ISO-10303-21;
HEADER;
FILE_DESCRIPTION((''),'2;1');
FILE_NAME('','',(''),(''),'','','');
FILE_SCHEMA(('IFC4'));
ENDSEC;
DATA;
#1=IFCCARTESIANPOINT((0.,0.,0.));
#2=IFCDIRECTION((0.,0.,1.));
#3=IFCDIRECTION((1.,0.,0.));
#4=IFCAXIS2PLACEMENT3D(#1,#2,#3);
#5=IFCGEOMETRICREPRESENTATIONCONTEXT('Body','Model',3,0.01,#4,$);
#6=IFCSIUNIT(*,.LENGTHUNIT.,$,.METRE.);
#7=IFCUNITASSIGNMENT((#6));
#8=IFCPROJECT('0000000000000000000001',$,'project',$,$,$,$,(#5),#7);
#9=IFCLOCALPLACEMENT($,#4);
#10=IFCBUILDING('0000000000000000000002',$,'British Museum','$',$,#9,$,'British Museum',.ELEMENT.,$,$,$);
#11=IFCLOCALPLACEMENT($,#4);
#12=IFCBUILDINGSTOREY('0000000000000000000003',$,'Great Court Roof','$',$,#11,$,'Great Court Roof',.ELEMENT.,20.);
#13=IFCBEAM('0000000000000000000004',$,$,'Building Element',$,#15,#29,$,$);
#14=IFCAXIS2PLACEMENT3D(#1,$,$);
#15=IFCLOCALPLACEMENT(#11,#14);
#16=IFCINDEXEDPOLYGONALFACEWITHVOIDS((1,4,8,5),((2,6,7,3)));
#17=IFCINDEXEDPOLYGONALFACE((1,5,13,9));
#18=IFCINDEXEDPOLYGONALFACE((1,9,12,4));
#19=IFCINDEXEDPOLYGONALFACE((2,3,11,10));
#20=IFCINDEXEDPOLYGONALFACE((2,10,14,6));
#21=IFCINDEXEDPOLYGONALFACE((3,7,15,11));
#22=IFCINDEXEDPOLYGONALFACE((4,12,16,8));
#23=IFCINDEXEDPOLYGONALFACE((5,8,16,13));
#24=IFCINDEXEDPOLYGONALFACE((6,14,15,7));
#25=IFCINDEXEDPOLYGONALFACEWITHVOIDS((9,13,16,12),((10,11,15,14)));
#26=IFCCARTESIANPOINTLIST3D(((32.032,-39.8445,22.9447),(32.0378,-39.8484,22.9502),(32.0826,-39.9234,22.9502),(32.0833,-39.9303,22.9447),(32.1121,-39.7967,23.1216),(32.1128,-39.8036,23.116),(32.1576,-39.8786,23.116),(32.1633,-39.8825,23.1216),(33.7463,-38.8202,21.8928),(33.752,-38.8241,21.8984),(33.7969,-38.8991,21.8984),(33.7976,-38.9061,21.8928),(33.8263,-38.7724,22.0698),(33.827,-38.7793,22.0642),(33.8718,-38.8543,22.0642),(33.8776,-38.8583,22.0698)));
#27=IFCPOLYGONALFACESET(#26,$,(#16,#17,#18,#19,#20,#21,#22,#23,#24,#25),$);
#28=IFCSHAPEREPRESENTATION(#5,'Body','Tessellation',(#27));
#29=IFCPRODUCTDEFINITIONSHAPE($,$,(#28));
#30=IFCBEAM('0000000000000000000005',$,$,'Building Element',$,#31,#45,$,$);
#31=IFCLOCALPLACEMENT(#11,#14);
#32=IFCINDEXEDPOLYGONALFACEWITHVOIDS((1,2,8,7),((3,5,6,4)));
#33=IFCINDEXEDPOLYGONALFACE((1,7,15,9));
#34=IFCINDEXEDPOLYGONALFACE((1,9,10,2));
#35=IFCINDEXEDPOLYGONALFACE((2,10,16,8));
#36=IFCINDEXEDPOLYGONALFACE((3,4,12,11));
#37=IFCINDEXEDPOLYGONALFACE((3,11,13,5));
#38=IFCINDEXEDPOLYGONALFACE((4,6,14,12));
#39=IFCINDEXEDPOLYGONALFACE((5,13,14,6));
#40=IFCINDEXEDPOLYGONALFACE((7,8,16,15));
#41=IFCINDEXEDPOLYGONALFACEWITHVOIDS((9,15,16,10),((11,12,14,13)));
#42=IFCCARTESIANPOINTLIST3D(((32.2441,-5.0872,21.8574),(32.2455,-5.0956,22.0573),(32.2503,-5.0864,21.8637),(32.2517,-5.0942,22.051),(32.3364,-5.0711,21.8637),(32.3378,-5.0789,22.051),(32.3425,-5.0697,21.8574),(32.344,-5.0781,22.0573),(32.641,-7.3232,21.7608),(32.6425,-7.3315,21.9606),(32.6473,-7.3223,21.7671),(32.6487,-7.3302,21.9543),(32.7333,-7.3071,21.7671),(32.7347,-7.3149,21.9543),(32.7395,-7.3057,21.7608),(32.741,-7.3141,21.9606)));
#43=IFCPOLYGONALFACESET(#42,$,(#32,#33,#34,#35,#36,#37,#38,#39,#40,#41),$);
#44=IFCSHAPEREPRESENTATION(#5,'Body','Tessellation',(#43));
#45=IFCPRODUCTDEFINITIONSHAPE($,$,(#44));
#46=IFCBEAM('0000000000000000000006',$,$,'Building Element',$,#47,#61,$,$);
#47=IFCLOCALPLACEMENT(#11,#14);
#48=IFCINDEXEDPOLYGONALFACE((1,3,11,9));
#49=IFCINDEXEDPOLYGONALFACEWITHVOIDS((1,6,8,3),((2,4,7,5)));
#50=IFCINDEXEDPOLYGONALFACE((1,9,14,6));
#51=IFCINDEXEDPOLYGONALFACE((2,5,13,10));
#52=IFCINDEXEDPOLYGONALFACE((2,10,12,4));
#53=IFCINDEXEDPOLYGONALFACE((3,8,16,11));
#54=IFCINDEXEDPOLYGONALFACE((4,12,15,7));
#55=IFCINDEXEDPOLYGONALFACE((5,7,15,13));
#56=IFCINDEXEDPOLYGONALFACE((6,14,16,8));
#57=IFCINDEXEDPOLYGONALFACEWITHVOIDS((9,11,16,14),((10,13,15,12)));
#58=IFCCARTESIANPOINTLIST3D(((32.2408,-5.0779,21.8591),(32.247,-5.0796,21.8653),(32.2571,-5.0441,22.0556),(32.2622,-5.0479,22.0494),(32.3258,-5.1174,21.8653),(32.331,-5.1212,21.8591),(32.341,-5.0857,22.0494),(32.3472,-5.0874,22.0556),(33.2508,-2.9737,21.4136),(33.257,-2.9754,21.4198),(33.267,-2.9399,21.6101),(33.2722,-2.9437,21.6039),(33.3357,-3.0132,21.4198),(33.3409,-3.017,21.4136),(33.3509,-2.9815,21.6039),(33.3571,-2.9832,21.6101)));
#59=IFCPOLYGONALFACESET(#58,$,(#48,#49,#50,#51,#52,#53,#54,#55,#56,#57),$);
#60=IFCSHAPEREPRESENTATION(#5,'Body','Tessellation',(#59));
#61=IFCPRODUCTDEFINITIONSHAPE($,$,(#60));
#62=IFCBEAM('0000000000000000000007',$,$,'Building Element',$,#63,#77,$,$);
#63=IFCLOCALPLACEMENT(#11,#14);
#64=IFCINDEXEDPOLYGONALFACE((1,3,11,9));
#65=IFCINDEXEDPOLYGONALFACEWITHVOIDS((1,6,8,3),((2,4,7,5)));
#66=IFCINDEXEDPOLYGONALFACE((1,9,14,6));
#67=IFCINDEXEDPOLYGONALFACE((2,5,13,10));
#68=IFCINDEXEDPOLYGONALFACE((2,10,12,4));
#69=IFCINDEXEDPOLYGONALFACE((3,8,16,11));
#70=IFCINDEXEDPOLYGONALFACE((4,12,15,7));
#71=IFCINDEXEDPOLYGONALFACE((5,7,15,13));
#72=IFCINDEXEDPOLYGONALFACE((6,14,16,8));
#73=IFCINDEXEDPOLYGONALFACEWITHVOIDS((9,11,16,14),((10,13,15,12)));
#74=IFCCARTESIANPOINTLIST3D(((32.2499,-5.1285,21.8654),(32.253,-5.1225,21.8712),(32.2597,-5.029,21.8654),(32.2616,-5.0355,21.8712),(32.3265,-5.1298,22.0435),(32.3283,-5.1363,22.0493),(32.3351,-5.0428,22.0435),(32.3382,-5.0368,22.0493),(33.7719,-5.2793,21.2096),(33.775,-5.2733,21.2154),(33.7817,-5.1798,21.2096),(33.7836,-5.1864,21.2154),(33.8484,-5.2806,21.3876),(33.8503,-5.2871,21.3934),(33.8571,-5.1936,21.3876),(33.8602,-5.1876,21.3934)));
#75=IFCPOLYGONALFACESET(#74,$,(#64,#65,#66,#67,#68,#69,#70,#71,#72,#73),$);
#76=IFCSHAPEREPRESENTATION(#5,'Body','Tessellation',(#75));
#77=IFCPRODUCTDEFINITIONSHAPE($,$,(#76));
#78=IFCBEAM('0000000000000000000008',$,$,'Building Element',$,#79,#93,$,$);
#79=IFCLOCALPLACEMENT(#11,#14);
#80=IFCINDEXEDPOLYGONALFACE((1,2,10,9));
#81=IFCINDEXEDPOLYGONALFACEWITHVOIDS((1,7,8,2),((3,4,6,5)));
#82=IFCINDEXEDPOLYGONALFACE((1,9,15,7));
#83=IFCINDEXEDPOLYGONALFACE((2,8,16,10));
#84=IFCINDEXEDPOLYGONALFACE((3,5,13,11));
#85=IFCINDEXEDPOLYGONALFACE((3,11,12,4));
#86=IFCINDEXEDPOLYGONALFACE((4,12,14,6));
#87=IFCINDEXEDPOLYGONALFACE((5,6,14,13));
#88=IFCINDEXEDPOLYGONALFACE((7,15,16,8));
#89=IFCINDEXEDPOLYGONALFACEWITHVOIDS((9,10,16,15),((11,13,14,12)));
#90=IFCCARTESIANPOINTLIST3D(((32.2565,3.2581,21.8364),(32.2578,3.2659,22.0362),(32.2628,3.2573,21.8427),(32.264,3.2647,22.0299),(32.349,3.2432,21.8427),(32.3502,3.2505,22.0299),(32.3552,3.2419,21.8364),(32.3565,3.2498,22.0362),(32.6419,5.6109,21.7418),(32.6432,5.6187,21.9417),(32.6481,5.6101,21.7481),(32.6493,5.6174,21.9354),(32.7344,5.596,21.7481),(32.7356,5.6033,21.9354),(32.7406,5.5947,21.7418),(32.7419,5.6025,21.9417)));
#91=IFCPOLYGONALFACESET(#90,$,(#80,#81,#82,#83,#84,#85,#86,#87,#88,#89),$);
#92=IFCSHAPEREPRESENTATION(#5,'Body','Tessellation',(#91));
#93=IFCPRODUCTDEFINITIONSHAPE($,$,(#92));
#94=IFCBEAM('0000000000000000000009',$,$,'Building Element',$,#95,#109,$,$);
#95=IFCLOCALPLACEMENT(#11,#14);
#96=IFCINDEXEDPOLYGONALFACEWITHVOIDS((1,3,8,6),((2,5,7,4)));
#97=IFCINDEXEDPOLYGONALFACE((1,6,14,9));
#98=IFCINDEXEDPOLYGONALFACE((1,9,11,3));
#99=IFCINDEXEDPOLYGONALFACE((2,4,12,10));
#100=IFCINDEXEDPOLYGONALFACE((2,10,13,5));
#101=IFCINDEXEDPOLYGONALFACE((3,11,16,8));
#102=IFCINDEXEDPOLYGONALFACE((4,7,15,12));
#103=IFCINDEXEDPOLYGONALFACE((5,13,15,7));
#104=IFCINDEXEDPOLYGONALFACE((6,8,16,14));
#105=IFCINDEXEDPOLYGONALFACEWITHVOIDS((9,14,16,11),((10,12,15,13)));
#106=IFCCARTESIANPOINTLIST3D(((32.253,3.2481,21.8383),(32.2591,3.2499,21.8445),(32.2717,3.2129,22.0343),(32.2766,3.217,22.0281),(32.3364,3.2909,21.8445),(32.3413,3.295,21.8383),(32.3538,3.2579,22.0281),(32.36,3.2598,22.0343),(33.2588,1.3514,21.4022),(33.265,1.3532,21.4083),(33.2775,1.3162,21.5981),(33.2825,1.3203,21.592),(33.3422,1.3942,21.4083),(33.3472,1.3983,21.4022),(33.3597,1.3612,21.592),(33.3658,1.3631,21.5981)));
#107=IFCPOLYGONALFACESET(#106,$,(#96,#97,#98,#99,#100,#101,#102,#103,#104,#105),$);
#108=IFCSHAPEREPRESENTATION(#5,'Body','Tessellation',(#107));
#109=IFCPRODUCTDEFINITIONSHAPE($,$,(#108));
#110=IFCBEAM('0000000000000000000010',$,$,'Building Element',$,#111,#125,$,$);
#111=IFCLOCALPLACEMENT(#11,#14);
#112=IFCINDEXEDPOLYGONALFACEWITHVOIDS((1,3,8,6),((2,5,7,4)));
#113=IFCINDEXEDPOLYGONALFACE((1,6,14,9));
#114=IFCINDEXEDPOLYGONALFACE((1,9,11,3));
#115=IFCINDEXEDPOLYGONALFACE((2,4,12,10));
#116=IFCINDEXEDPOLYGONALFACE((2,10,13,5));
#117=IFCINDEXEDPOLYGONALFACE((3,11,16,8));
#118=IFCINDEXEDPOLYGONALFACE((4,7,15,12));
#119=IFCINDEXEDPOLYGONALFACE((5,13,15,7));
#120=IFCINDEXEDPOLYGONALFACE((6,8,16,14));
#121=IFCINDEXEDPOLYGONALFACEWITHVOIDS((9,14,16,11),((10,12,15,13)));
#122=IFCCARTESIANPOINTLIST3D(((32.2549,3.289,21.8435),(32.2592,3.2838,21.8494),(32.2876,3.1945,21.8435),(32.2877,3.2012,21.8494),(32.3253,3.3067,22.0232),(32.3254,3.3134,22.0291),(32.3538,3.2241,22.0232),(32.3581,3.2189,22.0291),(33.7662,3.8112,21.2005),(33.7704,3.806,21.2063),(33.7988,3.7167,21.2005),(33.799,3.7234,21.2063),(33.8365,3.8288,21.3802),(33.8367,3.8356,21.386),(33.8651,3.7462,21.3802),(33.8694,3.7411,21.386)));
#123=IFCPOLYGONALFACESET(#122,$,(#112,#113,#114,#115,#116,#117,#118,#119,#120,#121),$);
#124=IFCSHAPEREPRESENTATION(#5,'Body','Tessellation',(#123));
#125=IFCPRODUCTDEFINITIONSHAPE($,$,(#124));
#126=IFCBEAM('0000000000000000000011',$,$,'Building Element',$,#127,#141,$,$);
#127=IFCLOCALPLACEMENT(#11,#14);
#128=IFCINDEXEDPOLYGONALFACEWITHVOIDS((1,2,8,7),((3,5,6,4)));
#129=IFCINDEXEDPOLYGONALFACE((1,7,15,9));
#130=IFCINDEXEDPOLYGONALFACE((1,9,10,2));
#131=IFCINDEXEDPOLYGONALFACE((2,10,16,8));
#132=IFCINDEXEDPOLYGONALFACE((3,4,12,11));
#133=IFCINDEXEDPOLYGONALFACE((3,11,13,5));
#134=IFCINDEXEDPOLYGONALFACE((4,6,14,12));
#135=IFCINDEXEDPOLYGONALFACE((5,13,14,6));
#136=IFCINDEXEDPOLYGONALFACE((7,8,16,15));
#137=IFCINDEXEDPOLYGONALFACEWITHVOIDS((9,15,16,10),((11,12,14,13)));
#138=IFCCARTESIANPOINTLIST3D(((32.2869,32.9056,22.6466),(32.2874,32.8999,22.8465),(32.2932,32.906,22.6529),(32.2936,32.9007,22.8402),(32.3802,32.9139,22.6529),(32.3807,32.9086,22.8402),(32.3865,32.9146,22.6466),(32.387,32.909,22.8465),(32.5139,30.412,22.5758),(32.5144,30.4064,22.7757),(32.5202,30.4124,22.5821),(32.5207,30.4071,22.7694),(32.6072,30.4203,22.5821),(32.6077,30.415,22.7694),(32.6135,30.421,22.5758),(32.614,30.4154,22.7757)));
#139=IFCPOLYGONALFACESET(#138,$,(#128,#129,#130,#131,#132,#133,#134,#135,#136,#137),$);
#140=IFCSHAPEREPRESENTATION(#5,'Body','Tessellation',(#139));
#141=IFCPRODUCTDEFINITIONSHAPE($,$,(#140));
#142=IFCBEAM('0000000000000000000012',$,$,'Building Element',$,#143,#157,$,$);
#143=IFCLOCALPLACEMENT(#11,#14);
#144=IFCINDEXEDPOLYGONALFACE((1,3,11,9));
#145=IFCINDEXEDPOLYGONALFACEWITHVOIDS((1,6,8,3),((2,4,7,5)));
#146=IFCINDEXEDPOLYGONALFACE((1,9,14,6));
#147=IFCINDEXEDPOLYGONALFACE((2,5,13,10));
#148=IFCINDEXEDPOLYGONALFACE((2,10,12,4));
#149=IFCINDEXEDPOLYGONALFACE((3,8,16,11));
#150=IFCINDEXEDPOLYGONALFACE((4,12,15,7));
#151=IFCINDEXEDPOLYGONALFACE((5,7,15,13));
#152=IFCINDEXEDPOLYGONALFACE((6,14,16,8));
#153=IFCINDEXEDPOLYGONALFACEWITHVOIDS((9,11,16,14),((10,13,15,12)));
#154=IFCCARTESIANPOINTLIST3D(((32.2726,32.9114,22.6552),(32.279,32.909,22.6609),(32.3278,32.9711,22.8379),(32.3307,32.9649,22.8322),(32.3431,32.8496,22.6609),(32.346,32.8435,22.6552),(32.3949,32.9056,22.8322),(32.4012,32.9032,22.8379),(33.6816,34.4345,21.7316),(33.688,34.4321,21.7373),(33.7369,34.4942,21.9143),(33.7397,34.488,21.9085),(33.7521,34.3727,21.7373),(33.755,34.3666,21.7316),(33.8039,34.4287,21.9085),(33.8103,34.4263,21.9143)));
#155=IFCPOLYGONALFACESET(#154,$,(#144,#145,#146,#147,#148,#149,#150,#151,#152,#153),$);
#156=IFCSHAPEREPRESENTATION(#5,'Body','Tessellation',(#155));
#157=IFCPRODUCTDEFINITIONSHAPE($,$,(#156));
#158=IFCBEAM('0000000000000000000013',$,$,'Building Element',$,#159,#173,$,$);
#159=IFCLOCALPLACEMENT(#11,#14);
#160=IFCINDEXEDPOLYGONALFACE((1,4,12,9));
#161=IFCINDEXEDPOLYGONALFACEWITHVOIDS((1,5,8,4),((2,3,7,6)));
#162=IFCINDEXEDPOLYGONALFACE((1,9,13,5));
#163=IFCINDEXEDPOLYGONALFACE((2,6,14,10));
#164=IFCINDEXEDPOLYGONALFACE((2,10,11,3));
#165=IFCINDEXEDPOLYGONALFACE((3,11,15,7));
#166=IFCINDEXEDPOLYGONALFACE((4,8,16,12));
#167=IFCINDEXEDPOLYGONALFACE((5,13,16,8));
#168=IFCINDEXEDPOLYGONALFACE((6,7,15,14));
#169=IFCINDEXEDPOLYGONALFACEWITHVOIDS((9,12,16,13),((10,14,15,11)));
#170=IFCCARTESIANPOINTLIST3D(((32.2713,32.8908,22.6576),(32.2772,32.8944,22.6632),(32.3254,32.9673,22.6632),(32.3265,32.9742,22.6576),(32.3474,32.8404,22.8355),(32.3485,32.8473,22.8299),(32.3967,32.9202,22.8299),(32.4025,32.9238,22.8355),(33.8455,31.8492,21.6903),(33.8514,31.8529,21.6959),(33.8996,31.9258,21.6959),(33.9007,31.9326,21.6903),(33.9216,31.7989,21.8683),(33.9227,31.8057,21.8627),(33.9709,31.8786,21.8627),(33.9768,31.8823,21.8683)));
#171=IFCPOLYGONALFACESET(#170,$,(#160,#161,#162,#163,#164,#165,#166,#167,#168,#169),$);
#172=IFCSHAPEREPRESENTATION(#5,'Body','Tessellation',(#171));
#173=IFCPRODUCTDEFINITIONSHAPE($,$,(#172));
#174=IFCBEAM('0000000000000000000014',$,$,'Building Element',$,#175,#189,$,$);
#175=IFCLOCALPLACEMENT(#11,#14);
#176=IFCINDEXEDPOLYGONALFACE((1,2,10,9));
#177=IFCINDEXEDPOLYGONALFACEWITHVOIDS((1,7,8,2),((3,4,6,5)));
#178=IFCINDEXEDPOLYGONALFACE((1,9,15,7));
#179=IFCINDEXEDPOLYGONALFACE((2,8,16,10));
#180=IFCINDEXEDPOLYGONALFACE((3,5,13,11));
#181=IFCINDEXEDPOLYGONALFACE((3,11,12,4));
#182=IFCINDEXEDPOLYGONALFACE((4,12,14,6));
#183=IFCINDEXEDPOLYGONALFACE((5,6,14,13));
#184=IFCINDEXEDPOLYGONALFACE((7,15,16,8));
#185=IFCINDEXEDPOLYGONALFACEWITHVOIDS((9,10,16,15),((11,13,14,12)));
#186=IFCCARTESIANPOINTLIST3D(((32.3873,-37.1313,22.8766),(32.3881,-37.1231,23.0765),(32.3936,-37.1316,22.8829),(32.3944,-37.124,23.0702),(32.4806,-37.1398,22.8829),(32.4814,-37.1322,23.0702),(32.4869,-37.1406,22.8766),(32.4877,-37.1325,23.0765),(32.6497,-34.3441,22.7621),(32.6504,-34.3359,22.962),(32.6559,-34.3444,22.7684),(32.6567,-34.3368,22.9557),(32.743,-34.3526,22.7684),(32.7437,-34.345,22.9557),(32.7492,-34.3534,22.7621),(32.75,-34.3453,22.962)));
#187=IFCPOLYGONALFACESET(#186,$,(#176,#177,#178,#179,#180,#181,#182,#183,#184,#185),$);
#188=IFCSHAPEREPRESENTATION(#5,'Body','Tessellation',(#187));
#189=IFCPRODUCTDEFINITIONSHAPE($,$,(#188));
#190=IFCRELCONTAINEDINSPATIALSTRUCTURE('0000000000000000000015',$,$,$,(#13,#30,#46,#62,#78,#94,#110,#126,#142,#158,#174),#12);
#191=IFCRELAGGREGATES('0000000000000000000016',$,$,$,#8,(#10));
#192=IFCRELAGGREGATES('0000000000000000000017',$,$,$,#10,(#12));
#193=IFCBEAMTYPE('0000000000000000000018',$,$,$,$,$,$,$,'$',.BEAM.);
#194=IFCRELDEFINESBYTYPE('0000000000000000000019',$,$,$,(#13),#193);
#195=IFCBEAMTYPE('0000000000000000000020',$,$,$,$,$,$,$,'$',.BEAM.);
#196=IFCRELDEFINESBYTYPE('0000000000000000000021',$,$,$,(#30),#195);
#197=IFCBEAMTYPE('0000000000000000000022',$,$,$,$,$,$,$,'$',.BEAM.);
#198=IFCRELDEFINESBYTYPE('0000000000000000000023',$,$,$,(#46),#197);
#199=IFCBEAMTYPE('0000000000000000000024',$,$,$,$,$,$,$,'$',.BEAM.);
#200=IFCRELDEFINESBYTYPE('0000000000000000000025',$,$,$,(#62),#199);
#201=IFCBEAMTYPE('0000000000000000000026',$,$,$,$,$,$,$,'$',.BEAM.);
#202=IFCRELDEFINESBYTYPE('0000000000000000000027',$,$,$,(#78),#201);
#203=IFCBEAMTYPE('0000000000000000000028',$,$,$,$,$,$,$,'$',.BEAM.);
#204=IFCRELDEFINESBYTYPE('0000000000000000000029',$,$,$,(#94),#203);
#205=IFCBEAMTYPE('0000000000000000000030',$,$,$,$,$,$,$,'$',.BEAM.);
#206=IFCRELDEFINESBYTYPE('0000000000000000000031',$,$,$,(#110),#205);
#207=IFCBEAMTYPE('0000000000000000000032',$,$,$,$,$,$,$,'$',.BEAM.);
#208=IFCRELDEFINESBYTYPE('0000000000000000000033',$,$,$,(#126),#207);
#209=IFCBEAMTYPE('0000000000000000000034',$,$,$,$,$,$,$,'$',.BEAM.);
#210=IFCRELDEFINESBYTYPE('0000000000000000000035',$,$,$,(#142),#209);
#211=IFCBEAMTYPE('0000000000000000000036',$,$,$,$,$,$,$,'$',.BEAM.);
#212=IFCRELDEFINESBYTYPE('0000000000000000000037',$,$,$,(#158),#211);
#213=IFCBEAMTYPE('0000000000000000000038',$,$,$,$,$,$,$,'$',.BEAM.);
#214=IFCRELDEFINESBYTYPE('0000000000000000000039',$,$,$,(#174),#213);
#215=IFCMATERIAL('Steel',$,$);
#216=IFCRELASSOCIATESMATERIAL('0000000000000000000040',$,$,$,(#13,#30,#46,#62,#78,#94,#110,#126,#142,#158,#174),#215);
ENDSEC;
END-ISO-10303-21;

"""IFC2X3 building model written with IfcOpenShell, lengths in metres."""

from ifc_helpers import new_model, si_unit, frame, origin_with_axes, origin_2d, place, context, project, spatial, hollow_rectangle, extrude, material, type_object, element, save


model = new_model("IFC2X3")

# Units and contexts
model_context = context("Model", 3, precision=0.01, world=origin_with_axes(), identifier="Body")
ifc_project = project(units=[si_unit("LENGTHUNIT", "METRE")], contexts=[model_context])

# Building, storey
building_placement = place(None, origin_with_axes())
building = spatial("IfcBuilding", under=ifc_project, at=building_placement, Name="British Museum", Description="$", LongName="British Museum", CompositionType="ELEMENT")
storey_placement = place(None, origin_with_axes())
storey = spatial("IfcBuildingStorey", under=building, at=storey_placement, Name="Great Court Roof", Description="$", LongName="Great Court Roof", CompositionType="ELEMENT", Elevation=20.0)

# Beams
ifc_material = material(Name="Steel")
beam_type_1 = type_object("IfcBeamType", ElementType="$", PredefinedType="BEAM")
beam_1_placement = place(None, origin_with_axes())
element("IfcBeam", 1, at=beam_1_placement, inside=storey, type_object=beam_type_1, material=ifc_material, Description="Building Element", context=model_context, shape_type="SweptSolid", body=[
    extrude(hollow_rectangle(XDim=0.1, YDim=0.2, WallThickness=0.0063, InnerFilletRadius=0.0, OuterFilletRadius=0.0, at=origin_2d()), frame((32.0977, -39.8635, 23.0331), z_axis=(0.759519, 0.453823, -0.466021), x_axis=(-0.512925, 0.858433, 0.0)), (0.0, 0.0, 1.0), 2.257),
])
beam_type_2 = type_object("IfcBeamType", ElementType="$", PredefinedType="BEAM")
beam_2_placement = place(None, origin_with_axes())
element("IfcBeam", 2, at=beam_2_placement, inside=storey, type_object=beam_type_2, material=ifc_material, Description="Building Element", context=model_context, shape_type="SweptSolid", body=[
    extrude(hollow_rectangle(XDim=0.1, YDim=0.2, WallThickness=0.0063, InnerFilletRadius=0.0, OuterFilletRadius=0.0, at=origin_2d()), frame((32.294, -5.0826, 21.9574), z_axis=(0.174651, -0.983712, -0.042526), x_axis=(0.984602, 0.174809, 0.0)), (0.0, 0.0, 1.0), 2.273),
])
beam_type_3 = type_object("IfcBeamType", ElementType="$", PredefinedType="BEAM")
beam_3_placement = place(None, origin_with_axes())
element("IfcBeam", 3, at=beam_3_placement, inside=storey, type_object=beam_type_3, material=ifc_material, Description="Building Element", context=model_context, shape_type="SweptSolid", body=[
    extrude(hollow_rectangle(XDim=0.1, YDim=0.2, WallThickness=0.0063, InnerFilletRadius=0.0, OuterFilletRadius=0.0, at=origin_2d()), frame((32.294, -5.0826, 21.9574), z_axis=(0.425024, 0.885553, -0.187482), x_axis=(-0.901539, 0.432697, 0.0)), (0.0, 0.0, 1.0), 2.3762),
])
beam_type_4 = type_object("IfcBeamType", ElementType="$", PredefinedType="BEAM")
beam_4_placement = place(None, origin_with_axes())
element("IfcBeam", 4, at=beam_4_placement, inside=storey, type_object=beam_type_4, material=ifc_material, Description="Building Element", context=model_context, shape_type="SweptSolid", body=[
    extrude(hollow_rectangle(XDim=0.1, YDim=0.2, WallThickness=0.0063, InnerFilletRadius=0.0, OuterFilletRadius=0.0, at=origin_2d()), frame((32.294, -5.0826, 21.9574), z_axis=(0.914582, -0.09064, -0.394112), x_axis=(0.098622, 0.995125, 0.0)), (0.0, 0.0, 1.0), 1.6641),
])
beam_type_5 = type_object("IfcBeamType", ElementType="$", PredefinedType="BEAM")
beam_5_placement = place(None, origin_with_axes())
element("IfcBeam", 5, at=beam_5_placement, inside=storey, type_object=beam_type_5, material=ifc_material, Description="Building Element", context=model_context, shape_type="SweptSolid", body=[
    extrude(hollow_rectangle(XDim=0.1, YDim=0.2, WallThickness=0.0063, InnerFilletRadius=0.0, OuterFilletRadius=0.0, at=origin_2d()), frame((32.3065, 3.2539, 21.9363), z_axis=(0.161514, 0.986075, -0.039628), x_axis=(-0.98685, 0.161641, 0.0)), (0.0, 0.0, 1.0), 2.386),
])
beam_type_6 = type_object("IfcBeamType", ElementType="$", PredefinedType="BEAM")
beam_6_placement = place(None, origin_with_axes())
element("IfcBeam", 6, at=beam_6_placement, inside=storey, type_object=beam_type_6, material=ifc_material, Description="Building Element", context=model_context, shape_type="SweptSolid", body=[
    extrude(hollow_rectangle(XDim=0.1, YDim=0.2, WallThickness=0.0063, InnerFilletRadius=0.0, OuterFilletRadius=0.0, at=origin_2d()), frame((32.3065, 3.2539, 21.9363), z_axis=(0.459132, -0.865771, -0.199094), x_axis=(0.883458, 0.468511, 0.0)), (0.0, 0.0, 1.0), 2.1908),
])
beam_type_7 = type_object("IfcBeamType", ElementType="$", PredefinedType="BEAM")
beam_7_placement = place(None, origin_with_axes())
element("IfcBeam", 7, at=beam_7_placement, inside=storey, type_object=beam_type_7, material=ifc_material, Description="Building Element", context=model_context, shape_type="SweptSolid", body=[
    extrude(hollow_rectangle(XDim=0.1, YDim=0.2, WallThickness=0.0063, InnerFilletRadius=0.0, OuterFilletRadius=0.0, at=origin_2d()), frame((32.3065, 3.2539, 21.9363), z_axis=(0.876903, 0.302998, -0.373139), x_axis=(-0.326586, 0.945168, 0.0)), (0.0, 0.0, 1.0), 1.7234),
])
beam_type_8 = type_object("IfcBeamType", ElementType="$", PredefinedType="BEAM")
beam_8_placement = place(None, origin_with_axes())
element("IfcBeam", 8, at=beam_8_placement, inside=storey, type_object=beam_type_8, material=ifc_material, Description="Building Element", context=model_context, shape_type="SweptSolid", body=[
    extrude(hollow_rectangle(XDim=0.1, YDim=0.2, WallThickness=0.0063, InnerFilletRadius=0.0, OuterFilletRadius=0.0, at=origin_2d()), frame((32.3369, 32.9073, 22.7465), z_axis=(0.090632, -0.995484, -0.02825), x_axis=(0.995881, 0.090668, 0.0)), (0.0, 0.0, 1.0), 2.5049),
])
beam_type_9 = type_object("IfcBeamType", ElementType="$", PredefinedType="BEAM")
beam_9_placement = place(None, origin_with_axes())
element("IfcBeam", 9, at=beam_9_placement, inside=storey, type_object=beam_type_9, material=ifc_material, Description="Building Element", context=model_context, shape_type="SweptSolid", body=[
    extrude(hollow_rectangle(XDim=0.1, YDim=0.2, WallThickness=0.0063, InnerFilletRadius=0.0, OuterFilletRadius=0.0, at=origin_2d()), frame((32.3369, 32.9073, 22.7465), z_axis=(0.620396, 0.67062, -0.406667), x_axis=(-0.73406, 0.679085, 0.0)), (0.0, 0.0, 1.0), 2.2712),
])
beam_type_10 = type_object("IfcBeamType", ElementType="$", PredefinedType="BEAM")
beam_10_placement = place(None, origin_with_axes())
element("IfcBeam", 10, at=beam_10_placement, inside=storey, type_object=beam_type_10, material=ifc_material, Description="Building Element", context=model_context, shape_type="SweptSolid", body=[
    extrude(hollow_rectangle(XDim=0.1, YDim=0.2, WallThickness=0.0063, InnerFilletRadius=0.0, OuterFilletRadius=0.0, at=origin_2d()), frame((32.3369, 32.9073, 22.7465), z_axis=(0.742209, -0.491061, -0.456053), x_axis=(0.551784, 0.833987, 0.0)), (0.0, 0.0, 1.0), 2.121),
])
beam_type_11 = type_object("IfcBeamType", ElementType="$", PredefinedType="BEAM")
beam_11_placement = place(None, origin_with_axes())
element("IfcBeam", 11, at=beam_11_placement, inside=storey, type_object=beam_type_11, material=ifc_material, Description="Building Element", context=model_context, shape_type="SweptSolid", body=[
    extrude(hollow_rectangle(XDim=0.1, YDim=0.2, WallThickness=0.0063, InnerFilletRadius=0.0, OuterFilletRadius=0.0, at=origin_2d()), frame((32.4375, -37.1319, 22.9765), z_axis=(0.093622, 0.994769, -0.040858), x_axis=(-0.9956, 0.0937, 0.0)), (0.0, 0.0, 1.0), 2.8018),
])

save(model, "model.ifc")
